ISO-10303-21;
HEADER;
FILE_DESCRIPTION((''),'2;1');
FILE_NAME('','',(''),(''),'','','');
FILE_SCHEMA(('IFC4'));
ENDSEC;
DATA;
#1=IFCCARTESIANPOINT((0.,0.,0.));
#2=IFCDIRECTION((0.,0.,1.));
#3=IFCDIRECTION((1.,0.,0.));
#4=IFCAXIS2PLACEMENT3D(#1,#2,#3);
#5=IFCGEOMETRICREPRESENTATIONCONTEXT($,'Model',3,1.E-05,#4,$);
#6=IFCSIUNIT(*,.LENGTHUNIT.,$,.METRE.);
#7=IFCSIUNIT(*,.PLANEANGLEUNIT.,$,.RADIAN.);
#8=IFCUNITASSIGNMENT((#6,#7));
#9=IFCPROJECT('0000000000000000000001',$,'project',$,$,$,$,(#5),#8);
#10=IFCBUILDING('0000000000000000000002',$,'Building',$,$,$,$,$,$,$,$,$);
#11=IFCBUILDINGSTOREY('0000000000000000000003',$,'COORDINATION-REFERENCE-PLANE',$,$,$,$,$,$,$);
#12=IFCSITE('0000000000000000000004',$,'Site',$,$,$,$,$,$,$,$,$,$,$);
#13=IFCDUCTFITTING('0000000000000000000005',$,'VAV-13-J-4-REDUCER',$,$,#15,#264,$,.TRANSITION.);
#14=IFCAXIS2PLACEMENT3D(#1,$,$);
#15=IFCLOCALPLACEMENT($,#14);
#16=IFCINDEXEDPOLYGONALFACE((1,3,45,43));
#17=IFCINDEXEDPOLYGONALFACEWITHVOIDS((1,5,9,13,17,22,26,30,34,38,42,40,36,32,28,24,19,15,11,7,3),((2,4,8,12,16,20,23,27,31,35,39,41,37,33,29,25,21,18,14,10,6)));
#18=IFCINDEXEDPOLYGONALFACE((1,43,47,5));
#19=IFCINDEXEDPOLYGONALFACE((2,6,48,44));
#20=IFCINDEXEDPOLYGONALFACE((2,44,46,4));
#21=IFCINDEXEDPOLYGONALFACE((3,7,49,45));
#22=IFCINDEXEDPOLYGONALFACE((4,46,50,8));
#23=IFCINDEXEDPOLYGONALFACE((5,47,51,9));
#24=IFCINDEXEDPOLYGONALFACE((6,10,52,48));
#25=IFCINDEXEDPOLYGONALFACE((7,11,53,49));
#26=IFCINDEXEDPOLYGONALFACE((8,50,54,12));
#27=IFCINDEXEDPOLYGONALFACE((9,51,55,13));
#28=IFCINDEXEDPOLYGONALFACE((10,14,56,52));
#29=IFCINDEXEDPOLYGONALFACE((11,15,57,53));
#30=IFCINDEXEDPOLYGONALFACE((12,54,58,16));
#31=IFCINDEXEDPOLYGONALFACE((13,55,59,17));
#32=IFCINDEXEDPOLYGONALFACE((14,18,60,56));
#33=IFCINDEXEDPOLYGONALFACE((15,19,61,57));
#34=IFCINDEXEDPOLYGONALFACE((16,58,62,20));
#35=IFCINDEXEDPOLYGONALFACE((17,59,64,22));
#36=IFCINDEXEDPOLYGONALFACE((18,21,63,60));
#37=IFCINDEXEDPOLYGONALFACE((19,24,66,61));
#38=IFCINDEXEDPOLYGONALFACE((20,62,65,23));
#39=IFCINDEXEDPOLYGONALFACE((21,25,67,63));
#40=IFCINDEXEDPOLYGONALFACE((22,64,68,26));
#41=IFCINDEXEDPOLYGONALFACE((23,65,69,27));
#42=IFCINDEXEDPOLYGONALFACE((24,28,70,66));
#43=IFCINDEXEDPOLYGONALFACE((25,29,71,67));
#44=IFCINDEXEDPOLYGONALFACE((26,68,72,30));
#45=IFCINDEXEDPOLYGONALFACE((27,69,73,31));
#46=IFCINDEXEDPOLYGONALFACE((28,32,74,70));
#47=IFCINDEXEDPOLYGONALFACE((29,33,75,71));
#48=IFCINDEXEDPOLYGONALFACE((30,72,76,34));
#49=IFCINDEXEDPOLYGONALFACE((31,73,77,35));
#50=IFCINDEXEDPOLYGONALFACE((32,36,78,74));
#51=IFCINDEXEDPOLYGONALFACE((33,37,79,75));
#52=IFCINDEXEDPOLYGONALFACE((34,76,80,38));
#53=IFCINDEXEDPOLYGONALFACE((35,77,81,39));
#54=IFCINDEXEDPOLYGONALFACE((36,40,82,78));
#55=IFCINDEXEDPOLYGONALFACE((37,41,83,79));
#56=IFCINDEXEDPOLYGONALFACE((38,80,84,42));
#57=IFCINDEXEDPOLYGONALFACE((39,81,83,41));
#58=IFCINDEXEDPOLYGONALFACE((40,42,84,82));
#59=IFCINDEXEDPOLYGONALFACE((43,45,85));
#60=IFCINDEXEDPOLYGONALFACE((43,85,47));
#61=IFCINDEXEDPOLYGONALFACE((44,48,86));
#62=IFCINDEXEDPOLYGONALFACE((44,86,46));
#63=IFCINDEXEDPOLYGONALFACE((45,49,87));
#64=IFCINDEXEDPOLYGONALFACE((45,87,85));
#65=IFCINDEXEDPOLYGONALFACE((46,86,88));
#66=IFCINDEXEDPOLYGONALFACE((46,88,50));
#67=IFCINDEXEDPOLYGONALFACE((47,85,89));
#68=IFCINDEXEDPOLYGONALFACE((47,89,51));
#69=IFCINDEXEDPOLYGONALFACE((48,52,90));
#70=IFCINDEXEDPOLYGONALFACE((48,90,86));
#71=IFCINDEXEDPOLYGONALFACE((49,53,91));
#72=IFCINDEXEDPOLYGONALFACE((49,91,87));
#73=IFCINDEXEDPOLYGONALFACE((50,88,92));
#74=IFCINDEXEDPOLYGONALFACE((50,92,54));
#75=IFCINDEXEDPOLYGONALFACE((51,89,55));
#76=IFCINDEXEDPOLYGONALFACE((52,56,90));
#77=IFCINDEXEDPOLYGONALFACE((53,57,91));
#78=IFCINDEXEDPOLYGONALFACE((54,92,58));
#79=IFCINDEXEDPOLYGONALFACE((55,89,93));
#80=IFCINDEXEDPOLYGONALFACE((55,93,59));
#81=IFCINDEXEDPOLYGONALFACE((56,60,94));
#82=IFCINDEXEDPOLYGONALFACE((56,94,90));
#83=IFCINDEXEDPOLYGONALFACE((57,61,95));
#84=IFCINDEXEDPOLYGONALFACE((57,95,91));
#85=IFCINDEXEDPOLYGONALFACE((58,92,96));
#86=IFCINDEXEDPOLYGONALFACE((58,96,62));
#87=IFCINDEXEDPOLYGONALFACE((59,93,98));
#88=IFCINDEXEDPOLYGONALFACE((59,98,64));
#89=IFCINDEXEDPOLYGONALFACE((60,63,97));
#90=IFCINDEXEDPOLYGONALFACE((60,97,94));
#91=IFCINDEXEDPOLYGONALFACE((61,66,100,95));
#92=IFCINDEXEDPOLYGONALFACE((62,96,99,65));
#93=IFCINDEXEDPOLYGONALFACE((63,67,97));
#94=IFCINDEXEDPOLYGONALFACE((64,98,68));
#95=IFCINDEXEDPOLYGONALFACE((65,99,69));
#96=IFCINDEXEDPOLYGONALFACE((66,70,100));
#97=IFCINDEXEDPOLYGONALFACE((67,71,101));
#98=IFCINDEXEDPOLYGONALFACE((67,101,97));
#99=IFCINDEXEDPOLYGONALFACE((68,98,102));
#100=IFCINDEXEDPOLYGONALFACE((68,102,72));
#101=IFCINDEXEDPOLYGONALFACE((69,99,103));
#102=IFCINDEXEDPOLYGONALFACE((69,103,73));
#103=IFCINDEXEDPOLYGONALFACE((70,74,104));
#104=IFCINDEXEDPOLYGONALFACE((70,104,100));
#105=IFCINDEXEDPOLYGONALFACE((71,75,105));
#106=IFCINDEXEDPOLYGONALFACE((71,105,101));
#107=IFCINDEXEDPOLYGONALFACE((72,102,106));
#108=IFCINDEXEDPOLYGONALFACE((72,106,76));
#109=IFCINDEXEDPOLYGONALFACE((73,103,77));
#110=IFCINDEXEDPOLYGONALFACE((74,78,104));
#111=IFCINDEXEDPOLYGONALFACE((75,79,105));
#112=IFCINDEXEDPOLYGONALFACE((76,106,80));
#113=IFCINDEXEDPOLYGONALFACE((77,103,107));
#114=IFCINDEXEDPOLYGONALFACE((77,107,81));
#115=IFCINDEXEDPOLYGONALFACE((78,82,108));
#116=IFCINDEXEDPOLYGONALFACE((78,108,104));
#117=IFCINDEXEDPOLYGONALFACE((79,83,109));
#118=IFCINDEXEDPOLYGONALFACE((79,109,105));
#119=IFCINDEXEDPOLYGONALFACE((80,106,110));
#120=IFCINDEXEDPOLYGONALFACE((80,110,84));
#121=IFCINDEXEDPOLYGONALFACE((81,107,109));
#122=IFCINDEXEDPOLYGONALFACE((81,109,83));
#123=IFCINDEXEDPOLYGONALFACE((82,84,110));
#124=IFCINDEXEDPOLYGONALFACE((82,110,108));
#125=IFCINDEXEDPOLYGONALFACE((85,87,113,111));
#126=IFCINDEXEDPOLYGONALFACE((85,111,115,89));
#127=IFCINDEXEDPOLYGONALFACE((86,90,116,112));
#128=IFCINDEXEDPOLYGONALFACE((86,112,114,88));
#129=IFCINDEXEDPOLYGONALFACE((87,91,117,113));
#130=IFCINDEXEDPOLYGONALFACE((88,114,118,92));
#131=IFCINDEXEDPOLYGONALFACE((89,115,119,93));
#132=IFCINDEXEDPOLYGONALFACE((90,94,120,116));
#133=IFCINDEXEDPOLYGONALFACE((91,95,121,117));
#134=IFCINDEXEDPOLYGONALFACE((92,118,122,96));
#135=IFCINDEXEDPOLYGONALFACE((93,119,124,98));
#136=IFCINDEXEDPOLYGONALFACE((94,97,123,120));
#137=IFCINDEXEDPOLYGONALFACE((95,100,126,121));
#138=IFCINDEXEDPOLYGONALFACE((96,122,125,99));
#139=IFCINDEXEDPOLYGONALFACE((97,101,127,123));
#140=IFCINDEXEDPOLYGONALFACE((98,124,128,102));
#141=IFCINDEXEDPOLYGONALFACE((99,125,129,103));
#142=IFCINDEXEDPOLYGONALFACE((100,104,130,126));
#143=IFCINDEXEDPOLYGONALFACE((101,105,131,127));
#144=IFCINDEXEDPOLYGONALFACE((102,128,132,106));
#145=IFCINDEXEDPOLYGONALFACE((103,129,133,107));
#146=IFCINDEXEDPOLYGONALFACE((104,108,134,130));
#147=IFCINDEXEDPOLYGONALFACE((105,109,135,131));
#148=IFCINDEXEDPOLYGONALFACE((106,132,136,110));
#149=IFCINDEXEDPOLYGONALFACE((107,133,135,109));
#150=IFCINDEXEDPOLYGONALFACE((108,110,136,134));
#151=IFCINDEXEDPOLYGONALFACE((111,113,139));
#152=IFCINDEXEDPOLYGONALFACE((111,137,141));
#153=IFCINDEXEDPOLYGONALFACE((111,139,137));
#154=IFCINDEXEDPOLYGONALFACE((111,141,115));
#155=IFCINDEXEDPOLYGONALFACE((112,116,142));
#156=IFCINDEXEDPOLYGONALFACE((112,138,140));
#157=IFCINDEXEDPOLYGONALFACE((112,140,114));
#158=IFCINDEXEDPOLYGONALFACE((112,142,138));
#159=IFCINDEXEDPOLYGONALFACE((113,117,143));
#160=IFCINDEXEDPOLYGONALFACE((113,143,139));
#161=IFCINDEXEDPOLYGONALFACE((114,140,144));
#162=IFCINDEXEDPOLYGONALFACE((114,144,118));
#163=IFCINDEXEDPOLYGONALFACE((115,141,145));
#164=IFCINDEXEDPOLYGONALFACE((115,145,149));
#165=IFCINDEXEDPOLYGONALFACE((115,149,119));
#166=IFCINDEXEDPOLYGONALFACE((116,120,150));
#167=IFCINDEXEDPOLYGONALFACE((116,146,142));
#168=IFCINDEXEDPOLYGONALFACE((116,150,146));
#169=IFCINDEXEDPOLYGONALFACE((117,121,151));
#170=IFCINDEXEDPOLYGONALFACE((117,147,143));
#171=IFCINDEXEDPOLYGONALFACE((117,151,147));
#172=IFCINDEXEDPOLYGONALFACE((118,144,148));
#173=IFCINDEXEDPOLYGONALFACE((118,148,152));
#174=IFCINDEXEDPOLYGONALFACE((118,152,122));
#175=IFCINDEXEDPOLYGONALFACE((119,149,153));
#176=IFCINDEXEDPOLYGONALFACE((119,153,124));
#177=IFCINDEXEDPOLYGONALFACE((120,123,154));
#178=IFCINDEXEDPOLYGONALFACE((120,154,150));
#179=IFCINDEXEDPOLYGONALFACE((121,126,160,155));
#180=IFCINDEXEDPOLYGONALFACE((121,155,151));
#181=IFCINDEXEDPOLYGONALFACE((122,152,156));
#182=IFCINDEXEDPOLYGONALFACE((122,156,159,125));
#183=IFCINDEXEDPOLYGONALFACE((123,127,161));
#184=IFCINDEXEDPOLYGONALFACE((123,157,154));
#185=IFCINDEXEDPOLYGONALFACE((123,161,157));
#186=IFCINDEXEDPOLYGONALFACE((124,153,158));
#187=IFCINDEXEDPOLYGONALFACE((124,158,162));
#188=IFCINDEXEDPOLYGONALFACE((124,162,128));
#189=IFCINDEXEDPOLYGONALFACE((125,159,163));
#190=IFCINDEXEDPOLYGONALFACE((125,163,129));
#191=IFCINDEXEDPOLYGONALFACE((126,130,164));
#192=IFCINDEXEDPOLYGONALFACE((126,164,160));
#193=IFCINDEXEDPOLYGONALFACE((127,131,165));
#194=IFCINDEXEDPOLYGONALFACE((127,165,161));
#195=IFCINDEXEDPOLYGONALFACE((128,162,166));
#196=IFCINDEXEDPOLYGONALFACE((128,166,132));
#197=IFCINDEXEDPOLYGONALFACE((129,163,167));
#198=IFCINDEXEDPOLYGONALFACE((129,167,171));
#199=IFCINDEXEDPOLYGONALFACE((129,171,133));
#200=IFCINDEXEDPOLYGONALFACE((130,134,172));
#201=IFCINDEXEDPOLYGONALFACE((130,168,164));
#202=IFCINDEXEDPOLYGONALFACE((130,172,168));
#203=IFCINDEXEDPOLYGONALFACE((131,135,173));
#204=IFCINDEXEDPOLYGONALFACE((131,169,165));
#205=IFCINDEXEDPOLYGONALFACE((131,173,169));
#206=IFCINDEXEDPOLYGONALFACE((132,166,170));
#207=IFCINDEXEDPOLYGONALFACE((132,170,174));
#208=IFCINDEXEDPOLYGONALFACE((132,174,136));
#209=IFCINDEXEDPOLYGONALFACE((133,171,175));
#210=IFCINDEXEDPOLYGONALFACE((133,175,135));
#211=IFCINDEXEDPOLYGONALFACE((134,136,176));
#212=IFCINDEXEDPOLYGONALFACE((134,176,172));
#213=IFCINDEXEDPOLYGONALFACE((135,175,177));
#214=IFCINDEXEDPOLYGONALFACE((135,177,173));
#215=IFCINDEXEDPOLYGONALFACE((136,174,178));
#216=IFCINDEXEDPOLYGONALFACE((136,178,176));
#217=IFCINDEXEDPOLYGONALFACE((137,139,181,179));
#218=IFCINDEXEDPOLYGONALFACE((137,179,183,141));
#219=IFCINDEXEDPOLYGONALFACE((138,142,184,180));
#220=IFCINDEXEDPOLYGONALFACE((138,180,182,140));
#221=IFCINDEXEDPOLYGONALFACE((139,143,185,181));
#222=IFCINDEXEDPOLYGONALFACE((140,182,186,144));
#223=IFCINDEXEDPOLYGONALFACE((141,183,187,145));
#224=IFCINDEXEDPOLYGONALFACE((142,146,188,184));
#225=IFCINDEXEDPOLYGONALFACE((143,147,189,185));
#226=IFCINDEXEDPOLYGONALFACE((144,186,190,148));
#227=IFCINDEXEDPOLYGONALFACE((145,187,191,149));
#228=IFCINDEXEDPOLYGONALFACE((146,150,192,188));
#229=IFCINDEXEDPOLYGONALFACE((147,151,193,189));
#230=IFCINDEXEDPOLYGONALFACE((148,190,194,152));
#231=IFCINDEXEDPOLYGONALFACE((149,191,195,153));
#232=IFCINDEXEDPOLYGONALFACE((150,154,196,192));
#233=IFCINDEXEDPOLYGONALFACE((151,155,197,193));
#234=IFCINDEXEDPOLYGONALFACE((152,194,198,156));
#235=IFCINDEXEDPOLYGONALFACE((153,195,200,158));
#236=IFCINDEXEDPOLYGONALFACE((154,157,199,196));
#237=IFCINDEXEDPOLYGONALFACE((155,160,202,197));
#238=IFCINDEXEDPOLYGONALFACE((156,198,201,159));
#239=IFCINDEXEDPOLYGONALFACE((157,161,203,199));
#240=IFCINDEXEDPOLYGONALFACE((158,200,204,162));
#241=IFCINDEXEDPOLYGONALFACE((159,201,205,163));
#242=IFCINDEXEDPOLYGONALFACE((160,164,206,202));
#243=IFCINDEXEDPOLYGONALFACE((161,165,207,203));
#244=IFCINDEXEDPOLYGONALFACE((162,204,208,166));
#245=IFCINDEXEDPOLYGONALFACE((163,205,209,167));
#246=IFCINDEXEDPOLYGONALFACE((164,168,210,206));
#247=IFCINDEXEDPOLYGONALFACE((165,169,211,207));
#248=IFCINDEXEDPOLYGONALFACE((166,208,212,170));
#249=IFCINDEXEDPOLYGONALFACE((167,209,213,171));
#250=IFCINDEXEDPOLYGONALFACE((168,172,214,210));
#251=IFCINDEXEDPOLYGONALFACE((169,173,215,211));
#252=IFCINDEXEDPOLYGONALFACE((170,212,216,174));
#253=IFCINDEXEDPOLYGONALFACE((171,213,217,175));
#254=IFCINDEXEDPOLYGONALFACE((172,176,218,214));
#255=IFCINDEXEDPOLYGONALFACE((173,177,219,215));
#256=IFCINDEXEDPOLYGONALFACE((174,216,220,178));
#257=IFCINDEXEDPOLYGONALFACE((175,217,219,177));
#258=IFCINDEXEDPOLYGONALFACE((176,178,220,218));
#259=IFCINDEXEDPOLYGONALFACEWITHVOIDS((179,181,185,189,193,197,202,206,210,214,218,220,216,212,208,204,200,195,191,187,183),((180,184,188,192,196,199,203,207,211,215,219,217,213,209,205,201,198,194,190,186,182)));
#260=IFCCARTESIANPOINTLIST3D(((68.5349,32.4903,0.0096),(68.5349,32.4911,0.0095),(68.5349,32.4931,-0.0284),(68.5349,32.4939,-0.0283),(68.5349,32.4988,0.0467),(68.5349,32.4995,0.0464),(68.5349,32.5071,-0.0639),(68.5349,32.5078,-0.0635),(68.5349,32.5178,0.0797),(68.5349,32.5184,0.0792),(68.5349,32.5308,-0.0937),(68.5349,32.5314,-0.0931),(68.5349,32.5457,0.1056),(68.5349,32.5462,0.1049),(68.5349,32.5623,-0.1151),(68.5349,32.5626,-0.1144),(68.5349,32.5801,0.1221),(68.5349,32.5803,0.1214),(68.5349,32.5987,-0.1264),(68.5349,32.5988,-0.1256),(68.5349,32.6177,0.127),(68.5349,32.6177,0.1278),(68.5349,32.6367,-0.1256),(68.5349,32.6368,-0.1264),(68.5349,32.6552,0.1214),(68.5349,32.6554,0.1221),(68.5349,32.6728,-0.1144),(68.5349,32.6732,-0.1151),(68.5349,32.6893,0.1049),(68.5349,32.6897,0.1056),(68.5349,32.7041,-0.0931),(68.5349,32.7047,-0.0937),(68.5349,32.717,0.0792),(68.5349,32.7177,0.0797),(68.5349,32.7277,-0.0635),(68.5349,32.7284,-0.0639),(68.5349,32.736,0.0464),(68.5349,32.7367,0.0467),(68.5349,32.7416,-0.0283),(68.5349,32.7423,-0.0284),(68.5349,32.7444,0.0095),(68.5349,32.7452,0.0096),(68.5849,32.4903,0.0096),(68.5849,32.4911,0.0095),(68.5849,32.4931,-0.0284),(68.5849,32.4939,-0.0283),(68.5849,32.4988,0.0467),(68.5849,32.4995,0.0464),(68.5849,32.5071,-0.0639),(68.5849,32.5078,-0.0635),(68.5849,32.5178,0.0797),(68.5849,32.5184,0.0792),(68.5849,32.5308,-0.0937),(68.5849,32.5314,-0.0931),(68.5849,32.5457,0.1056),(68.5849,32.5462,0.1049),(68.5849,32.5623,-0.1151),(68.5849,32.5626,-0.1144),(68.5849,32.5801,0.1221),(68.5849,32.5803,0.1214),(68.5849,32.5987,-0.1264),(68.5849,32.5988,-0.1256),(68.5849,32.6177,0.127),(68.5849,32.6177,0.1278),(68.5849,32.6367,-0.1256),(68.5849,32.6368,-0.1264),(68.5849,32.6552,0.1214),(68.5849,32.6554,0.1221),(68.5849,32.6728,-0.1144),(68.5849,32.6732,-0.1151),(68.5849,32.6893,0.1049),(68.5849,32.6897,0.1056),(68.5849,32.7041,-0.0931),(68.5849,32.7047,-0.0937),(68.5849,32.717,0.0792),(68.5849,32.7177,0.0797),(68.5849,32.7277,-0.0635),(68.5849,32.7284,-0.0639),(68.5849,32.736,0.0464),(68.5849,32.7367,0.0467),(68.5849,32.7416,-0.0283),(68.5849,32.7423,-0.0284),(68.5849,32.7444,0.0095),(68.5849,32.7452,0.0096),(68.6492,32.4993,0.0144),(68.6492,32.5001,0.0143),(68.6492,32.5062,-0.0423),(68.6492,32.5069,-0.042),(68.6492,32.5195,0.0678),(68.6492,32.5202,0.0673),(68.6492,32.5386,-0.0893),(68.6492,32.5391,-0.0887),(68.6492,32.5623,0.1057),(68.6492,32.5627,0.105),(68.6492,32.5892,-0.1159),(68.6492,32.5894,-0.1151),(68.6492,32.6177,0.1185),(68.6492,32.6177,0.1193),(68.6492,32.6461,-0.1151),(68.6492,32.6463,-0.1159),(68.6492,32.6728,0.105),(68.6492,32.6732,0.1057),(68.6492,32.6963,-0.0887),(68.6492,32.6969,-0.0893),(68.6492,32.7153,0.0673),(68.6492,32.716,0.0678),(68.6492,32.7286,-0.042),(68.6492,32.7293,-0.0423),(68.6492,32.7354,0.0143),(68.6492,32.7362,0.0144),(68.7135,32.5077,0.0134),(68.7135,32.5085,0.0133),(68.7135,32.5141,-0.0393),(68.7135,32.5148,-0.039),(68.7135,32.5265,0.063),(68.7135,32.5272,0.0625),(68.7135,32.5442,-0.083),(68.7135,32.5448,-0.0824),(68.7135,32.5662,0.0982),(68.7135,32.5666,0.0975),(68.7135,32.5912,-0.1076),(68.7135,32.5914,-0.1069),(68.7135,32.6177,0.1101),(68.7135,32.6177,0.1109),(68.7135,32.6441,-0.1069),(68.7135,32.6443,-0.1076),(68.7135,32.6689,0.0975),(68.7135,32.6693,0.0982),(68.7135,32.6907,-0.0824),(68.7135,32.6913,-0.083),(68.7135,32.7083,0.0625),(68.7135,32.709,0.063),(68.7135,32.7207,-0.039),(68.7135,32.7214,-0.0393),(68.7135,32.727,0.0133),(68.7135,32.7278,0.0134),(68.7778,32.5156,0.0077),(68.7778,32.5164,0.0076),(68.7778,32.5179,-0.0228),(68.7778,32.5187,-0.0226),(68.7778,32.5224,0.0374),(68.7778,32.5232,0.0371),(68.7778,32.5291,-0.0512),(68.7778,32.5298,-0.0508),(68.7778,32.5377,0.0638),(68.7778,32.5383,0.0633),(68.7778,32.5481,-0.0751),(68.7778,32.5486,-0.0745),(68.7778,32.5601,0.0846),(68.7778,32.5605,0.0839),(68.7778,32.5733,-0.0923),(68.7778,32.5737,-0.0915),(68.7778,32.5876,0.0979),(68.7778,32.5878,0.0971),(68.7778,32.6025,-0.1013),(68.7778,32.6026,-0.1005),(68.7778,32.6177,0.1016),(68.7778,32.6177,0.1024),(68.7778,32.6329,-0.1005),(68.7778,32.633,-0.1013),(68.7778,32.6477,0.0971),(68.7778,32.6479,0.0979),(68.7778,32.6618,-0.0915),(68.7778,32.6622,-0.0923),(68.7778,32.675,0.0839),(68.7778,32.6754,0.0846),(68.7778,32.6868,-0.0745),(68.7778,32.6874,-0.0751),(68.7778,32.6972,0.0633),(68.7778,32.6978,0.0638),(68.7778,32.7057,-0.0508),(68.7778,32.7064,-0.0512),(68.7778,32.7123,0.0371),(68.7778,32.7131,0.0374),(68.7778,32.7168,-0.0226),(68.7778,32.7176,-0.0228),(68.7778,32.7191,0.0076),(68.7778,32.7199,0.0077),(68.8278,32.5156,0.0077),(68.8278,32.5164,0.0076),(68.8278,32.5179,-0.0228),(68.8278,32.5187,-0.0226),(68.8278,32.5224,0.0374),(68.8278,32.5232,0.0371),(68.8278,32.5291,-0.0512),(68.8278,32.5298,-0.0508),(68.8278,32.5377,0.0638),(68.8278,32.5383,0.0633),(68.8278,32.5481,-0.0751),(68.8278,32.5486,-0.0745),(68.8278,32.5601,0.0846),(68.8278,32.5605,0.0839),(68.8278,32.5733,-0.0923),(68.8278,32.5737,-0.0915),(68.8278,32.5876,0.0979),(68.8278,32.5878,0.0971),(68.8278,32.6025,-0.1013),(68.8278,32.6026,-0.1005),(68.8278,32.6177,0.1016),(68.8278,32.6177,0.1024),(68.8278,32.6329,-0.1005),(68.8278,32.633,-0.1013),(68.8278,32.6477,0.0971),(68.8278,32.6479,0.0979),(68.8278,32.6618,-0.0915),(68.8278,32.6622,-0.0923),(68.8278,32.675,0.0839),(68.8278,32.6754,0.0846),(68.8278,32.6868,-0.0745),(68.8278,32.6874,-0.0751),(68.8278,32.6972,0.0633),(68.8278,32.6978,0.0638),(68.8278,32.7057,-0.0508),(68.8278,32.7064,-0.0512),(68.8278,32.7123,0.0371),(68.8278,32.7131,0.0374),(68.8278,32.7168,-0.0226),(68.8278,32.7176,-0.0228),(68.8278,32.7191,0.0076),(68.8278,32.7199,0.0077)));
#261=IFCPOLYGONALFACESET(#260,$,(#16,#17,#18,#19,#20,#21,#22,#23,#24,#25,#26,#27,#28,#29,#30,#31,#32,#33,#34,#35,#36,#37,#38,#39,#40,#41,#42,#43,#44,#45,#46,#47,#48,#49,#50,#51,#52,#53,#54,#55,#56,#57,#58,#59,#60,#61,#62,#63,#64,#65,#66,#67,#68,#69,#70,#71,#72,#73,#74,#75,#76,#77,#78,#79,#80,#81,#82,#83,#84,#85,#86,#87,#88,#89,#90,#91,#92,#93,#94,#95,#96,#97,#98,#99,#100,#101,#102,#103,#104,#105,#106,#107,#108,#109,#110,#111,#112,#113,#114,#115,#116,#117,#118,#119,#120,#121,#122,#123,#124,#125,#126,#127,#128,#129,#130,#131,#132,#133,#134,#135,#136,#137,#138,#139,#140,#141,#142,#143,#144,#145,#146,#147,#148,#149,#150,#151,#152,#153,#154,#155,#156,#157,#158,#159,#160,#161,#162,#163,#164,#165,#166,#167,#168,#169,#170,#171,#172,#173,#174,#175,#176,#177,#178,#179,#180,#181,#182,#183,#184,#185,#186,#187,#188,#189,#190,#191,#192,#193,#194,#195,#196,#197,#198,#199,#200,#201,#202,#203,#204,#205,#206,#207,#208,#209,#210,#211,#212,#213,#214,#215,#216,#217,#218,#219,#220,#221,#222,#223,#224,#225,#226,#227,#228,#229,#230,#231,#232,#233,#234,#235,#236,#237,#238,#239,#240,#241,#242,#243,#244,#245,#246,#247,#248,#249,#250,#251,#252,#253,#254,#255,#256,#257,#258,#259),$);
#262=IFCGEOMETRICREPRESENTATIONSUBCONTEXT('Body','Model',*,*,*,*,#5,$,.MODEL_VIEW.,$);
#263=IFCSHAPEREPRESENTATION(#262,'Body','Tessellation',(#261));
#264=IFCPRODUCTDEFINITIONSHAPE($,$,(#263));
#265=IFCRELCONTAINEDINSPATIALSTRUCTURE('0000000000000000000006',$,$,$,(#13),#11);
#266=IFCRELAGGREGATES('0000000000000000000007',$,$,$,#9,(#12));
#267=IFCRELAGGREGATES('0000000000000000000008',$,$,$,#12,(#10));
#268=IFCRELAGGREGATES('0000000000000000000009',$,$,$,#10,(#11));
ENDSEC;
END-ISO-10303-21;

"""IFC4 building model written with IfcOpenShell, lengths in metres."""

from ifc_helpers import new_model, entity, si_unit, frame, origin_with_axes, place, context, subcontext, project, spatial, element, save


model = new_model("IFC4")

# Units and contexts
model_context = context("Model", 3, precision=1e-05, world=origin_with_axes())
body_context_1 = subcontext(model_context, "Body", "Model", "MODEL_VIEW")
ifc_project = project(units=[si_unit("LENGTHUNIT", "METRE"), si_unit("PLANEANGLEUNIT", "RADIAN")], contexts=[model_context])

# Site, building, storey
site = spatial("IfcSite", under=ifc_project, Name="Site")
building = spatial("IfcBuilding", under=site, Name="Building")
storey = spatial("IfcBuildingStorey", under=building, Name="COORDINATION-REFERENCE-PLANE")

# Duct fitting
for number, where, z_axis, x_axis, name in (
    (1, (68.5349, 32.6177, 0.0), (0.0, 1.0, 0.0), (0.0, 0.0, 1.0), "VAV-13-J-4-REDUCER"),
):
    element("IfcDuctFitting", number, at=place(None, frame(where, z_axis=z_axis, x_axis=x_axis)), inside=storey, Name=name, PredefinedType="TRANSITION", context=body_context_1, shape_type="SweptSolid", body=[
        entity("IfcRevolvedAreaSolid", entity("IfcArbitraryClosedProfileDef", "AREA", None, entity("IfcPolyline", [entity("IfcCartesianPoint", [0.1278, 0.0]), entity("IfcCartesianPoint", [0.1278, 0.05]), entity("IfcCartesianPoint", [0.1024, 0.2429]), entity("IfcCartesianPoint", [0.1024, 0.2929]), entity("IfcCartesianPoint", [0.1016, 0.2929]), entity("IfcCartesianPoint", [0.1016, 0.2429]), entity("IfcCartesianPoint", [0.127, 0.05]), entity("IfcCartesianPoint", [0.127, 0.0]), entity("IfcCartesianPoint", [0.1278, 0.0])])), entity("IfcAxis2Placement3D", entity("IfcCartesianPoint", [0.0, 0.0, 0.0])), entity("IfcAxis1Placement", entity("IfcCartesianPoint", [0.0, 0.0, 0.0]), entity("IfcDirection", [0.0, 1.0, 0.0])), 6.283185),
    ])

save(model, "model.ifc")
